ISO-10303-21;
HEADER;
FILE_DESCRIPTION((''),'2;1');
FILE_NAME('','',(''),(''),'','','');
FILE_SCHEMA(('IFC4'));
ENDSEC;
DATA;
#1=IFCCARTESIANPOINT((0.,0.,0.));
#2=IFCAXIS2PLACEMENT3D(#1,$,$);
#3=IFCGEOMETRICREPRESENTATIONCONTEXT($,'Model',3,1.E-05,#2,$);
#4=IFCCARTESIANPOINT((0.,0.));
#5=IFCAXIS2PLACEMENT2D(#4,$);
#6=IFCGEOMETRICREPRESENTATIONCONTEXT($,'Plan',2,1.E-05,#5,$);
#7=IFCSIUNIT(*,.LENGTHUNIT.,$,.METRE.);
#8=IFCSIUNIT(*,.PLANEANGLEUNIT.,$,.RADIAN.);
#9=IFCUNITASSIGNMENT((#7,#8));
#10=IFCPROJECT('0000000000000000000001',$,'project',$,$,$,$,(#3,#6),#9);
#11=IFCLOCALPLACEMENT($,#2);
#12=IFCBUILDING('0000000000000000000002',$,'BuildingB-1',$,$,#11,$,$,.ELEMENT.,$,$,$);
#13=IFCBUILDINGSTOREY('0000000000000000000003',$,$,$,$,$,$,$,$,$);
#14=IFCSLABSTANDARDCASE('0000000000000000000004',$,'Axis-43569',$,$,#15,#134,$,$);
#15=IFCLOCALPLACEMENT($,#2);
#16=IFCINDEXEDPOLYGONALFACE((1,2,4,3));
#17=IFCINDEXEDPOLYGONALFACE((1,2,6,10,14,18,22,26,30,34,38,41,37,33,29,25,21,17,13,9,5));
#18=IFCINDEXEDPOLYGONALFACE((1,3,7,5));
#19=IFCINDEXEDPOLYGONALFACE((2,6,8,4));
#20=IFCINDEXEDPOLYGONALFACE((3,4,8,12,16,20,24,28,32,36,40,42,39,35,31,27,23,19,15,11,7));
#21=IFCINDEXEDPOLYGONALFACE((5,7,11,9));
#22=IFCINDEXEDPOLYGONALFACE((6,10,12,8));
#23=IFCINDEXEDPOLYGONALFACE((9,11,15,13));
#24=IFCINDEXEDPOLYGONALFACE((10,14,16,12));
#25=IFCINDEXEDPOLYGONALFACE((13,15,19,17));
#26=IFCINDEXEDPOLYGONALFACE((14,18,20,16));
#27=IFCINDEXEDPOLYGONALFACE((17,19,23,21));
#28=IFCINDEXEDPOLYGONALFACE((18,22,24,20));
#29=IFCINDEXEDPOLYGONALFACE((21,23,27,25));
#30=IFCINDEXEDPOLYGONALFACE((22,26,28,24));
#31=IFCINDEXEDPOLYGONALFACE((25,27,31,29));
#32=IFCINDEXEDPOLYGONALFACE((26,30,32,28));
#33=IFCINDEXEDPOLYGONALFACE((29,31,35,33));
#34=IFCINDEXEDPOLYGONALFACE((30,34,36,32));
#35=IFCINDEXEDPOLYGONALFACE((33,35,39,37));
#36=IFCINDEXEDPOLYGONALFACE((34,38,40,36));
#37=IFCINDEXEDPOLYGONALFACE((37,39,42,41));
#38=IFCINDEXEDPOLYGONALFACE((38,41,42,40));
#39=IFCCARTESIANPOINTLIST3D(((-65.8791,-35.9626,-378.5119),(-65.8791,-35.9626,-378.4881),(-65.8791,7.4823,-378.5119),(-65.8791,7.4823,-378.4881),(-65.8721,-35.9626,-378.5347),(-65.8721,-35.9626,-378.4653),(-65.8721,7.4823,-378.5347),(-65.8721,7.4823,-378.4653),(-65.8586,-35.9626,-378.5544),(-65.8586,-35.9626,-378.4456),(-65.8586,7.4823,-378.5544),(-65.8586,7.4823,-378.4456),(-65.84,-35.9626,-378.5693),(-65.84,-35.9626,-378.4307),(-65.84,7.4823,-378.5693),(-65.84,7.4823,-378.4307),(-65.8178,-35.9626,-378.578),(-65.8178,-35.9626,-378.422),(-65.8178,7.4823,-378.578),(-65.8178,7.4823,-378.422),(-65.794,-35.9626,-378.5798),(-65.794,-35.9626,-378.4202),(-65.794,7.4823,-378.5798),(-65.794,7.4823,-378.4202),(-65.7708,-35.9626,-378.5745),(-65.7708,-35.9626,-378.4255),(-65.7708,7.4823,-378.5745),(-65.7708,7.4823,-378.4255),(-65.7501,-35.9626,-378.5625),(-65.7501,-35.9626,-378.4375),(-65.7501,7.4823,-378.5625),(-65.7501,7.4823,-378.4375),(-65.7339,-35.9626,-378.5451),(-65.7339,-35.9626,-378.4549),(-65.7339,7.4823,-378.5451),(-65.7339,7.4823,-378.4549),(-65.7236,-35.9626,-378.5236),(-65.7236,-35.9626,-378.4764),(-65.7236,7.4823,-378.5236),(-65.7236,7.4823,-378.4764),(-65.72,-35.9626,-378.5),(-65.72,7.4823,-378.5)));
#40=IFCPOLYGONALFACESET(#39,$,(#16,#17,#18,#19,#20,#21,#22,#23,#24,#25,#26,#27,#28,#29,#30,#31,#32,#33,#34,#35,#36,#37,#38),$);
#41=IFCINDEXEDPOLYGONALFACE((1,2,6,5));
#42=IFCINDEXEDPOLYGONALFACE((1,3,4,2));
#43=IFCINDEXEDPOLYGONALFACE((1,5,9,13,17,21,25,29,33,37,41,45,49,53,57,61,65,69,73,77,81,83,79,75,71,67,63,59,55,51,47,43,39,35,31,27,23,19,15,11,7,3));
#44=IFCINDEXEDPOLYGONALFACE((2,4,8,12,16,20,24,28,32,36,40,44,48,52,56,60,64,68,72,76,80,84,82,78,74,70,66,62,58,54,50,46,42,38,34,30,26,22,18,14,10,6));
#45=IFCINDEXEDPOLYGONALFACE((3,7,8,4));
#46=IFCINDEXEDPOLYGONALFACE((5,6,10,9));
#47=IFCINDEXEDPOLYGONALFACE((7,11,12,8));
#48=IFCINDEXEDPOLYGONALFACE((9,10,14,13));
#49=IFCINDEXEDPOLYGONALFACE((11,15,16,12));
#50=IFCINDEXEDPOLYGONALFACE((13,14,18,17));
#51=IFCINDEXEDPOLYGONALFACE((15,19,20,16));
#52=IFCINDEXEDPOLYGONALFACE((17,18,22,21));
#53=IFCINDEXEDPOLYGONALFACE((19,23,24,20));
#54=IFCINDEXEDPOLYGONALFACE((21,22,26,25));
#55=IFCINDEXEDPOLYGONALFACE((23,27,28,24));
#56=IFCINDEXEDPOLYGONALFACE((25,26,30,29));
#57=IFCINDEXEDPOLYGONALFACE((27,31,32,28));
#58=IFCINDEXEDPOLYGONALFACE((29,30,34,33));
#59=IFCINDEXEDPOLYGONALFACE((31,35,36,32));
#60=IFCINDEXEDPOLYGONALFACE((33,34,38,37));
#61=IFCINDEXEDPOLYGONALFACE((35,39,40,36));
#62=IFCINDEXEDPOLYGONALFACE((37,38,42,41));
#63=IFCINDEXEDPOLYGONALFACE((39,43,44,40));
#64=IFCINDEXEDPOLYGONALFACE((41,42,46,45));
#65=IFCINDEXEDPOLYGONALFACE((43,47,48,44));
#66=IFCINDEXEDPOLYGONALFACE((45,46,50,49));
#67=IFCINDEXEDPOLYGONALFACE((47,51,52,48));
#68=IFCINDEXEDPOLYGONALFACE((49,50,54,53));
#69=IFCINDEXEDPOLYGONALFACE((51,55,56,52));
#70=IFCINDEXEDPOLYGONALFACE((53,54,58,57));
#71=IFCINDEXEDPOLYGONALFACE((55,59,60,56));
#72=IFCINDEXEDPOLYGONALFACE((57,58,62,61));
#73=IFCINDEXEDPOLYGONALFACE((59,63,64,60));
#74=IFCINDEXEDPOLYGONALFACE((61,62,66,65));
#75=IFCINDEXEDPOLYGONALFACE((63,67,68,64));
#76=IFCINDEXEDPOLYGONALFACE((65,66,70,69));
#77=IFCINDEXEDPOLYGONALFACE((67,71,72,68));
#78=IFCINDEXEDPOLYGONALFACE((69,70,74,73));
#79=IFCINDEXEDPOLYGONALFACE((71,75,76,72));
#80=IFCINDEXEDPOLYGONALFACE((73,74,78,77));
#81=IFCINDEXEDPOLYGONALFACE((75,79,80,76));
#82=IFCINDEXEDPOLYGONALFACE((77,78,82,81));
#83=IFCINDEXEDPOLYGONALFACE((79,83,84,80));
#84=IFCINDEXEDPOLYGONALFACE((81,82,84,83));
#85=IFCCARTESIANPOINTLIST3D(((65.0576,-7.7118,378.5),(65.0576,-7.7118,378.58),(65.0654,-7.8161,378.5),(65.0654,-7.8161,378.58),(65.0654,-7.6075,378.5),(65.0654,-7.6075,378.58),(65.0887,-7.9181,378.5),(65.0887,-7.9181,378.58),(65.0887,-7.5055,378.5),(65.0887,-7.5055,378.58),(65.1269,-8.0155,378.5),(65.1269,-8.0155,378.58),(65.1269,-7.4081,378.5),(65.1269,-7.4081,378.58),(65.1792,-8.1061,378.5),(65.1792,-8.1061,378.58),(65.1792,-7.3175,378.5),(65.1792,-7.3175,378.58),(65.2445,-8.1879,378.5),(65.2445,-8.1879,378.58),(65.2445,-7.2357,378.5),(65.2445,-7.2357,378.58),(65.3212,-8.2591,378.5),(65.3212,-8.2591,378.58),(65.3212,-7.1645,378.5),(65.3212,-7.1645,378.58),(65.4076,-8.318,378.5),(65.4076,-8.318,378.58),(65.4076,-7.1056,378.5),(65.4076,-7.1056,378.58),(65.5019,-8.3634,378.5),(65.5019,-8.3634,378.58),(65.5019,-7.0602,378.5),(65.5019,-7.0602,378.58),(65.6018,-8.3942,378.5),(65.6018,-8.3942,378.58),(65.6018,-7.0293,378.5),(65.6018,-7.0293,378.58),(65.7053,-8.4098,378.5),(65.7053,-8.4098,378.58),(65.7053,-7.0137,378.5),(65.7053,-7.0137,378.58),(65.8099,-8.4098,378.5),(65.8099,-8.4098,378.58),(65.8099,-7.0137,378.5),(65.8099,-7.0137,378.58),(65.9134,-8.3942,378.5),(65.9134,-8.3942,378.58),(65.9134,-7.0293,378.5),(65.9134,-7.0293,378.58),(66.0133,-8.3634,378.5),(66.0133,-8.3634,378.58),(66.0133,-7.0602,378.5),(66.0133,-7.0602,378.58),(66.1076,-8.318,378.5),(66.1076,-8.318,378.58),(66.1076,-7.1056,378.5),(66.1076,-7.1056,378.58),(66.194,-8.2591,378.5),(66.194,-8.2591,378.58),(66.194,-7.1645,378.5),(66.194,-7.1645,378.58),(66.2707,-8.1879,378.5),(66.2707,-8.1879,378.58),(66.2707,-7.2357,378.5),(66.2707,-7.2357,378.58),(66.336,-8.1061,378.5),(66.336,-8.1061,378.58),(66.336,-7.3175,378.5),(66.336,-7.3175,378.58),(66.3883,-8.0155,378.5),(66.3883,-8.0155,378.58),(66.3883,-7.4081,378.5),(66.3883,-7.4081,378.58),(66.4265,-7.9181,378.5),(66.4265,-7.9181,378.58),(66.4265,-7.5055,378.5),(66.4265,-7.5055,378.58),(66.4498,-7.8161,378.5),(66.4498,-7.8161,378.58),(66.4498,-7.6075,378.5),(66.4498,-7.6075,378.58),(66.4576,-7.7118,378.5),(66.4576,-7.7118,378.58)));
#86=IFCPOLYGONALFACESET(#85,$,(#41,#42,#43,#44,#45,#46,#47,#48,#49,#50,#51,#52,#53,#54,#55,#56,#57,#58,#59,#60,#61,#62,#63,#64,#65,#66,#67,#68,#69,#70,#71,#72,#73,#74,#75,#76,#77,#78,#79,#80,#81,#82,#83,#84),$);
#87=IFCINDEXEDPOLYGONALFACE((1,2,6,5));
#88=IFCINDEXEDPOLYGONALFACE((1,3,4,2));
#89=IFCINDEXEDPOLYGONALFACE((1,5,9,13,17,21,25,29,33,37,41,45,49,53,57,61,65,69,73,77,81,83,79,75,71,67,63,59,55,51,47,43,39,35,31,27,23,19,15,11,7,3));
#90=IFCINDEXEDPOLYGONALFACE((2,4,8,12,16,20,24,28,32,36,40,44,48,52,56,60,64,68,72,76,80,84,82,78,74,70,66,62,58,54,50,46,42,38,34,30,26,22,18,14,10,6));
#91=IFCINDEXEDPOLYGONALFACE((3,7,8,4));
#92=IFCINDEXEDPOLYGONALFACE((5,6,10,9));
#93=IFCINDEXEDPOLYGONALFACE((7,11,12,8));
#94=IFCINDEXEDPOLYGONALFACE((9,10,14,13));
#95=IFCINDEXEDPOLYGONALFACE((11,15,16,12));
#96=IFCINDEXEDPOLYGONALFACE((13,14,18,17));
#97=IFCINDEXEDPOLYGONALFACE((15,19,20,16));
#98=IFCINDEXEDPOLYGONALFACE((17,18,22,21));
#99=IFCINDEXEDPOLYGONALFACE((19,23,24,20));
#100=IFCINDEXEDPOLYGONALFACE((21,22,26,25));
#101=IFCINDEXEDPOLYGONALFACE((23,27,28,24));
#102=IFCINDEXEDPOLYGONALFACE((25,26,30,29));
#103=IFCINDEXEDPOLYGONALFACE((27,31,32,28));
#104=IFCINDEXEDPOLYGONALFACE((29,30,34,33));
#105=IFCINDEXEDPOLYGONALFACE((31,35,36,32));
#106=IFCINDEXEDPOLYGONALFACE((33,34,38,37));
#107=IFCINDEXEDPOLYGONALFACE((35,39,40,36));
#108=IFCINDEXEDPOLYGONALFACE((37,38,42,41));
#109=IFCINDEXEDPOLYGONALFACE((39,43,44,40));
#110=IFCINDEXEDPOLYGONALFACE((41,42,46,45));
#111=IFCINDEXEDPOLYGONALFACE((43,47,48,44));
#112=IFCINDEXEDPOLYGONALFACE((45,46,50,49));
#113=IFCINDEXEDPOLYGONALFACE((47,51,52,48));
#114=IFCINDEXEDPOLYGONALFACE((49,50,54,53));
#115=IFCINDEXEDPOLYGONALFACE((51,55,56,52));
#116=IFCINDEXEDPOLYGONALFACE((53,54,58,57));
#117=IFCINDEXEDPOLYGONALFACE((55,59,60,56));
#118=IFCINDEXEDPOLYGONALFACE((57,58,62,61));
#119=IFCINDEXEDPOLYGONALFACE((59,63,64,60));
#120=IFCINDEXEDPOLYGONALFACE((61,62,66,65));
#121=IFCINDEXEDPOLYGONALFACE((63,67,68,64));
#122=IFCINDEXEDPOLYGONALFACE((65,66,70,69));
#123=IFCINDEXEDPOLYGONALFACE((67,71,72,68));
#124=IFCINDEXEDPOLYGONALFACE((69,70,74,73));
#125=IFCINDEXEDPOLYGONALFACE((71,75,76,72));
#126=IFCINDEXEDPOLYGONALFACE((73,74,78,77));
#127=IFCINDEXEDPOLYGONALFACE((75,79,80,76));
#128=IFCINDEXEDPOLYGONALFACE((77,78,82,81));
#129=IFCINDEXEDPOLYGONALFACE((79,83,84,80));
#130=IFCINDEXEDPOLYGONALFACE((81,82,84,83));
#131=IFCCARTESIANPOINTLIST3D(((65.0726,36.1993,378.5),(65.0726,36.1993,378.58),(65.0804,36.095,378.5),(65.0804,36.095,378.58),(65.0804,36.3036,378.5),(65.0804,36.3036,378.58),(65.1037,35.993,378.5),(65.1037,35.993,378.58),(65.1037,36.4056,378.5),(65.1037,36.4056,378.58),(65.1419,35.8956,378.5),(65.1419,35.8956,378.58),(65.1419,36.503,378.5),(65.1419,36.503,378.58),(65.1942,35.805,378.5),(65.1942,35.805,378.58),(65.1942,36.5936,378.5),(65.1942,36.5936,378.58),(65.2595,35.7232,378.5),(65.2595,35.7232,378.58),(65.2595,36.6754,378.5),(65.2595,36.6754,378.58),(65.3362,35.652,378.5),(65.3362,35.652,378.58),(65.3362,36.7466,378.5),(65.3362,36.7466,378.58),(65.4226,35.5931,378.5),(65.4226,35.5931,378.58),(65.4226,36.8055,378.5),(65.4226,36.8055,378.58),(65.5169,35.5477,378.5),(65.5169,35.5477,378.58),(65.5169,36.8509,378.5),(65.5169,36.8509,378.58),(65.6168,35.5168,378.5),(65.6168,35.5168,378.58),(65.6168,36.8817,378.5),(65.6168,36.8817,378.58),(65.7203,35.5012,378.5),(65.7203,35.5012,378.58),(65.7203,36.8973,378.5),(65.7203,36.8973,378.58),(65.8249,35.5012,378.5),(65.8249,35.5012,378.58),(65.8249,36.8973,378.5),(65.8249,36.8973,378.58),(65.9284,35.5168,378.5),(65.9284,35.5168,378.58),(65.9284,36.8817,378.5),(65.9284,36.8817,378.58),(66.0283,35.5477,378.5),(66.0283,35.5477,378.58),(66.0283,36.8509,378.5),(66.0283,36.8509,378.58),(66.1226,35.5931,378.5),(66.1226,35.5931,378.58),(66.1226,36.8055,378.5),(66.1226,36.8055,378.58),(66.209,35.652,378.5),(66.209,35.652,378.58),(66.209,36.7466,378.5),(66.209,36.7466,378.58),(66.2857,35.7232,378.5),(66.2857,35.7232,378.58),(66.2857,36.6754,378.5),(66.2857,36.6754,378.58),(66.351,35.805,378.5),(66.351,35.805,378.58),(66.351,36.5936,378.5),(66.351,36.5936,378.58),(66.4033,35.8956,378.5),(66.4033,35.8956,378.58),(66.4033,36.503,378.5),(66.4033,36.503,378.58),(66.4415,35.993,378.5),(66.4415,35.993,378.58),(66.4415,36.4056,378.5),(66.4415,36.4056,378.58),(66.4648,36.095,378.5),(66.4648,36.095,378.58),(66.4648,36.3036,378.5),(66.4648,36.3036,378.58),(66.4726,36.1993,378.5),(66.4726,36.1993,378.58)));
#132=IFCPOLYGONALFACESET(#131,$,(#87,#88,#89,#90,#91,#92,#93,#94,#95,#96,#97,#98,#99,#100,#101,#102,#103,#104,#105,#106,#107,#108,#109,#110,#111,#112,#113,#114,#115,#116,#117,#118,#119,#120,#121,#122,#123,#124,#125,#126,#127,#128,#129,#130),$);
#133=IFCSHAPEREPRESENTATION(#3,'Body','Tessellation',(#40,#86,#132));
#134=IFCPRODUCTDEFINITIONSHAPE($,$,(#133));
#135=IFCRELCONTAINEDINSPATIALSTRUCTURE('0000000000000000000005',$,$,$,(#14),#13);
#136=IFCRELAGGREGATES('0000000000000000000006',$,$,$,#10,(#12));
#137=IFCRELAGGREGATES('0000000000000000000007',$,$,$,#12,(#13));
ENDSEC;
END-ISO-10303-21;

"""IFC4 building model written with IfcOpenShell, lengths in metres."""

from ifc_helpers import new_model, entity, si_unit, frame, origin, origin_2d, place, context, project, spatial, circle, extrude, element, save


model = new_model("IFC4")

# Units and contexts
model_context = context("Model", 3, precision=1e-05, world=origin())
plan_context = context("Plan", 2, precision=1e-05, world=origin_2d())
ifc_project = project(units=[si_unit("LENGTHUNIT", "METRE"), si_unit("PLANEANGLEUNIT", "RADIAN")], contexts=[model_context, plan_context])

# Building, storey
building_placement = place(None, origin())
building = spatial("IfcBuilding", under=ifc_project, at=building_placement, Name="BuildingB-1", CompositionType="ELEMENT")
storey = spatial("IfcBuildingStorey", under=building)

# Slab
element("IfcSlabStandardCase", 1, inside=storey, Name="Axis-43569", context=model_context, shape_type="AdvancedSweptSolid", body=[
    entity("IfcSurfaceCurveSweptAreaSolid", entity("IfcCircleProfileDef", "AREA", None, None, 0.08), None, entity("IfcPolyline", [entity("IfcCartesianPoint", [65.8, -7.4823, 378.5]), entity("IfcCartesianPoint", [65.8, 35.9626, 378.5])]), None, None, entity("IfcPlane", entity("IfcAxis2Placement3D", entity("IfcCartesianPoint", [65.8, -7.4823, 378.5]), entity("IfcDirection", [0.0, 0.0, 1.0]), entity("IfcDirection", [1.0, 0.0, 0.0])))),
    extrude(circle(Radius=0.7), frame((65.7576, -7.7118, 378.5)), (0.0, 0.0, 1.0), 0.08),
    extrude(circle(Radius=0.7), frame((65.7726, 36.1993, 378.5)), (0.0, 0.0, 1.0), 0.08),
])

save(model, "model.ifc")
